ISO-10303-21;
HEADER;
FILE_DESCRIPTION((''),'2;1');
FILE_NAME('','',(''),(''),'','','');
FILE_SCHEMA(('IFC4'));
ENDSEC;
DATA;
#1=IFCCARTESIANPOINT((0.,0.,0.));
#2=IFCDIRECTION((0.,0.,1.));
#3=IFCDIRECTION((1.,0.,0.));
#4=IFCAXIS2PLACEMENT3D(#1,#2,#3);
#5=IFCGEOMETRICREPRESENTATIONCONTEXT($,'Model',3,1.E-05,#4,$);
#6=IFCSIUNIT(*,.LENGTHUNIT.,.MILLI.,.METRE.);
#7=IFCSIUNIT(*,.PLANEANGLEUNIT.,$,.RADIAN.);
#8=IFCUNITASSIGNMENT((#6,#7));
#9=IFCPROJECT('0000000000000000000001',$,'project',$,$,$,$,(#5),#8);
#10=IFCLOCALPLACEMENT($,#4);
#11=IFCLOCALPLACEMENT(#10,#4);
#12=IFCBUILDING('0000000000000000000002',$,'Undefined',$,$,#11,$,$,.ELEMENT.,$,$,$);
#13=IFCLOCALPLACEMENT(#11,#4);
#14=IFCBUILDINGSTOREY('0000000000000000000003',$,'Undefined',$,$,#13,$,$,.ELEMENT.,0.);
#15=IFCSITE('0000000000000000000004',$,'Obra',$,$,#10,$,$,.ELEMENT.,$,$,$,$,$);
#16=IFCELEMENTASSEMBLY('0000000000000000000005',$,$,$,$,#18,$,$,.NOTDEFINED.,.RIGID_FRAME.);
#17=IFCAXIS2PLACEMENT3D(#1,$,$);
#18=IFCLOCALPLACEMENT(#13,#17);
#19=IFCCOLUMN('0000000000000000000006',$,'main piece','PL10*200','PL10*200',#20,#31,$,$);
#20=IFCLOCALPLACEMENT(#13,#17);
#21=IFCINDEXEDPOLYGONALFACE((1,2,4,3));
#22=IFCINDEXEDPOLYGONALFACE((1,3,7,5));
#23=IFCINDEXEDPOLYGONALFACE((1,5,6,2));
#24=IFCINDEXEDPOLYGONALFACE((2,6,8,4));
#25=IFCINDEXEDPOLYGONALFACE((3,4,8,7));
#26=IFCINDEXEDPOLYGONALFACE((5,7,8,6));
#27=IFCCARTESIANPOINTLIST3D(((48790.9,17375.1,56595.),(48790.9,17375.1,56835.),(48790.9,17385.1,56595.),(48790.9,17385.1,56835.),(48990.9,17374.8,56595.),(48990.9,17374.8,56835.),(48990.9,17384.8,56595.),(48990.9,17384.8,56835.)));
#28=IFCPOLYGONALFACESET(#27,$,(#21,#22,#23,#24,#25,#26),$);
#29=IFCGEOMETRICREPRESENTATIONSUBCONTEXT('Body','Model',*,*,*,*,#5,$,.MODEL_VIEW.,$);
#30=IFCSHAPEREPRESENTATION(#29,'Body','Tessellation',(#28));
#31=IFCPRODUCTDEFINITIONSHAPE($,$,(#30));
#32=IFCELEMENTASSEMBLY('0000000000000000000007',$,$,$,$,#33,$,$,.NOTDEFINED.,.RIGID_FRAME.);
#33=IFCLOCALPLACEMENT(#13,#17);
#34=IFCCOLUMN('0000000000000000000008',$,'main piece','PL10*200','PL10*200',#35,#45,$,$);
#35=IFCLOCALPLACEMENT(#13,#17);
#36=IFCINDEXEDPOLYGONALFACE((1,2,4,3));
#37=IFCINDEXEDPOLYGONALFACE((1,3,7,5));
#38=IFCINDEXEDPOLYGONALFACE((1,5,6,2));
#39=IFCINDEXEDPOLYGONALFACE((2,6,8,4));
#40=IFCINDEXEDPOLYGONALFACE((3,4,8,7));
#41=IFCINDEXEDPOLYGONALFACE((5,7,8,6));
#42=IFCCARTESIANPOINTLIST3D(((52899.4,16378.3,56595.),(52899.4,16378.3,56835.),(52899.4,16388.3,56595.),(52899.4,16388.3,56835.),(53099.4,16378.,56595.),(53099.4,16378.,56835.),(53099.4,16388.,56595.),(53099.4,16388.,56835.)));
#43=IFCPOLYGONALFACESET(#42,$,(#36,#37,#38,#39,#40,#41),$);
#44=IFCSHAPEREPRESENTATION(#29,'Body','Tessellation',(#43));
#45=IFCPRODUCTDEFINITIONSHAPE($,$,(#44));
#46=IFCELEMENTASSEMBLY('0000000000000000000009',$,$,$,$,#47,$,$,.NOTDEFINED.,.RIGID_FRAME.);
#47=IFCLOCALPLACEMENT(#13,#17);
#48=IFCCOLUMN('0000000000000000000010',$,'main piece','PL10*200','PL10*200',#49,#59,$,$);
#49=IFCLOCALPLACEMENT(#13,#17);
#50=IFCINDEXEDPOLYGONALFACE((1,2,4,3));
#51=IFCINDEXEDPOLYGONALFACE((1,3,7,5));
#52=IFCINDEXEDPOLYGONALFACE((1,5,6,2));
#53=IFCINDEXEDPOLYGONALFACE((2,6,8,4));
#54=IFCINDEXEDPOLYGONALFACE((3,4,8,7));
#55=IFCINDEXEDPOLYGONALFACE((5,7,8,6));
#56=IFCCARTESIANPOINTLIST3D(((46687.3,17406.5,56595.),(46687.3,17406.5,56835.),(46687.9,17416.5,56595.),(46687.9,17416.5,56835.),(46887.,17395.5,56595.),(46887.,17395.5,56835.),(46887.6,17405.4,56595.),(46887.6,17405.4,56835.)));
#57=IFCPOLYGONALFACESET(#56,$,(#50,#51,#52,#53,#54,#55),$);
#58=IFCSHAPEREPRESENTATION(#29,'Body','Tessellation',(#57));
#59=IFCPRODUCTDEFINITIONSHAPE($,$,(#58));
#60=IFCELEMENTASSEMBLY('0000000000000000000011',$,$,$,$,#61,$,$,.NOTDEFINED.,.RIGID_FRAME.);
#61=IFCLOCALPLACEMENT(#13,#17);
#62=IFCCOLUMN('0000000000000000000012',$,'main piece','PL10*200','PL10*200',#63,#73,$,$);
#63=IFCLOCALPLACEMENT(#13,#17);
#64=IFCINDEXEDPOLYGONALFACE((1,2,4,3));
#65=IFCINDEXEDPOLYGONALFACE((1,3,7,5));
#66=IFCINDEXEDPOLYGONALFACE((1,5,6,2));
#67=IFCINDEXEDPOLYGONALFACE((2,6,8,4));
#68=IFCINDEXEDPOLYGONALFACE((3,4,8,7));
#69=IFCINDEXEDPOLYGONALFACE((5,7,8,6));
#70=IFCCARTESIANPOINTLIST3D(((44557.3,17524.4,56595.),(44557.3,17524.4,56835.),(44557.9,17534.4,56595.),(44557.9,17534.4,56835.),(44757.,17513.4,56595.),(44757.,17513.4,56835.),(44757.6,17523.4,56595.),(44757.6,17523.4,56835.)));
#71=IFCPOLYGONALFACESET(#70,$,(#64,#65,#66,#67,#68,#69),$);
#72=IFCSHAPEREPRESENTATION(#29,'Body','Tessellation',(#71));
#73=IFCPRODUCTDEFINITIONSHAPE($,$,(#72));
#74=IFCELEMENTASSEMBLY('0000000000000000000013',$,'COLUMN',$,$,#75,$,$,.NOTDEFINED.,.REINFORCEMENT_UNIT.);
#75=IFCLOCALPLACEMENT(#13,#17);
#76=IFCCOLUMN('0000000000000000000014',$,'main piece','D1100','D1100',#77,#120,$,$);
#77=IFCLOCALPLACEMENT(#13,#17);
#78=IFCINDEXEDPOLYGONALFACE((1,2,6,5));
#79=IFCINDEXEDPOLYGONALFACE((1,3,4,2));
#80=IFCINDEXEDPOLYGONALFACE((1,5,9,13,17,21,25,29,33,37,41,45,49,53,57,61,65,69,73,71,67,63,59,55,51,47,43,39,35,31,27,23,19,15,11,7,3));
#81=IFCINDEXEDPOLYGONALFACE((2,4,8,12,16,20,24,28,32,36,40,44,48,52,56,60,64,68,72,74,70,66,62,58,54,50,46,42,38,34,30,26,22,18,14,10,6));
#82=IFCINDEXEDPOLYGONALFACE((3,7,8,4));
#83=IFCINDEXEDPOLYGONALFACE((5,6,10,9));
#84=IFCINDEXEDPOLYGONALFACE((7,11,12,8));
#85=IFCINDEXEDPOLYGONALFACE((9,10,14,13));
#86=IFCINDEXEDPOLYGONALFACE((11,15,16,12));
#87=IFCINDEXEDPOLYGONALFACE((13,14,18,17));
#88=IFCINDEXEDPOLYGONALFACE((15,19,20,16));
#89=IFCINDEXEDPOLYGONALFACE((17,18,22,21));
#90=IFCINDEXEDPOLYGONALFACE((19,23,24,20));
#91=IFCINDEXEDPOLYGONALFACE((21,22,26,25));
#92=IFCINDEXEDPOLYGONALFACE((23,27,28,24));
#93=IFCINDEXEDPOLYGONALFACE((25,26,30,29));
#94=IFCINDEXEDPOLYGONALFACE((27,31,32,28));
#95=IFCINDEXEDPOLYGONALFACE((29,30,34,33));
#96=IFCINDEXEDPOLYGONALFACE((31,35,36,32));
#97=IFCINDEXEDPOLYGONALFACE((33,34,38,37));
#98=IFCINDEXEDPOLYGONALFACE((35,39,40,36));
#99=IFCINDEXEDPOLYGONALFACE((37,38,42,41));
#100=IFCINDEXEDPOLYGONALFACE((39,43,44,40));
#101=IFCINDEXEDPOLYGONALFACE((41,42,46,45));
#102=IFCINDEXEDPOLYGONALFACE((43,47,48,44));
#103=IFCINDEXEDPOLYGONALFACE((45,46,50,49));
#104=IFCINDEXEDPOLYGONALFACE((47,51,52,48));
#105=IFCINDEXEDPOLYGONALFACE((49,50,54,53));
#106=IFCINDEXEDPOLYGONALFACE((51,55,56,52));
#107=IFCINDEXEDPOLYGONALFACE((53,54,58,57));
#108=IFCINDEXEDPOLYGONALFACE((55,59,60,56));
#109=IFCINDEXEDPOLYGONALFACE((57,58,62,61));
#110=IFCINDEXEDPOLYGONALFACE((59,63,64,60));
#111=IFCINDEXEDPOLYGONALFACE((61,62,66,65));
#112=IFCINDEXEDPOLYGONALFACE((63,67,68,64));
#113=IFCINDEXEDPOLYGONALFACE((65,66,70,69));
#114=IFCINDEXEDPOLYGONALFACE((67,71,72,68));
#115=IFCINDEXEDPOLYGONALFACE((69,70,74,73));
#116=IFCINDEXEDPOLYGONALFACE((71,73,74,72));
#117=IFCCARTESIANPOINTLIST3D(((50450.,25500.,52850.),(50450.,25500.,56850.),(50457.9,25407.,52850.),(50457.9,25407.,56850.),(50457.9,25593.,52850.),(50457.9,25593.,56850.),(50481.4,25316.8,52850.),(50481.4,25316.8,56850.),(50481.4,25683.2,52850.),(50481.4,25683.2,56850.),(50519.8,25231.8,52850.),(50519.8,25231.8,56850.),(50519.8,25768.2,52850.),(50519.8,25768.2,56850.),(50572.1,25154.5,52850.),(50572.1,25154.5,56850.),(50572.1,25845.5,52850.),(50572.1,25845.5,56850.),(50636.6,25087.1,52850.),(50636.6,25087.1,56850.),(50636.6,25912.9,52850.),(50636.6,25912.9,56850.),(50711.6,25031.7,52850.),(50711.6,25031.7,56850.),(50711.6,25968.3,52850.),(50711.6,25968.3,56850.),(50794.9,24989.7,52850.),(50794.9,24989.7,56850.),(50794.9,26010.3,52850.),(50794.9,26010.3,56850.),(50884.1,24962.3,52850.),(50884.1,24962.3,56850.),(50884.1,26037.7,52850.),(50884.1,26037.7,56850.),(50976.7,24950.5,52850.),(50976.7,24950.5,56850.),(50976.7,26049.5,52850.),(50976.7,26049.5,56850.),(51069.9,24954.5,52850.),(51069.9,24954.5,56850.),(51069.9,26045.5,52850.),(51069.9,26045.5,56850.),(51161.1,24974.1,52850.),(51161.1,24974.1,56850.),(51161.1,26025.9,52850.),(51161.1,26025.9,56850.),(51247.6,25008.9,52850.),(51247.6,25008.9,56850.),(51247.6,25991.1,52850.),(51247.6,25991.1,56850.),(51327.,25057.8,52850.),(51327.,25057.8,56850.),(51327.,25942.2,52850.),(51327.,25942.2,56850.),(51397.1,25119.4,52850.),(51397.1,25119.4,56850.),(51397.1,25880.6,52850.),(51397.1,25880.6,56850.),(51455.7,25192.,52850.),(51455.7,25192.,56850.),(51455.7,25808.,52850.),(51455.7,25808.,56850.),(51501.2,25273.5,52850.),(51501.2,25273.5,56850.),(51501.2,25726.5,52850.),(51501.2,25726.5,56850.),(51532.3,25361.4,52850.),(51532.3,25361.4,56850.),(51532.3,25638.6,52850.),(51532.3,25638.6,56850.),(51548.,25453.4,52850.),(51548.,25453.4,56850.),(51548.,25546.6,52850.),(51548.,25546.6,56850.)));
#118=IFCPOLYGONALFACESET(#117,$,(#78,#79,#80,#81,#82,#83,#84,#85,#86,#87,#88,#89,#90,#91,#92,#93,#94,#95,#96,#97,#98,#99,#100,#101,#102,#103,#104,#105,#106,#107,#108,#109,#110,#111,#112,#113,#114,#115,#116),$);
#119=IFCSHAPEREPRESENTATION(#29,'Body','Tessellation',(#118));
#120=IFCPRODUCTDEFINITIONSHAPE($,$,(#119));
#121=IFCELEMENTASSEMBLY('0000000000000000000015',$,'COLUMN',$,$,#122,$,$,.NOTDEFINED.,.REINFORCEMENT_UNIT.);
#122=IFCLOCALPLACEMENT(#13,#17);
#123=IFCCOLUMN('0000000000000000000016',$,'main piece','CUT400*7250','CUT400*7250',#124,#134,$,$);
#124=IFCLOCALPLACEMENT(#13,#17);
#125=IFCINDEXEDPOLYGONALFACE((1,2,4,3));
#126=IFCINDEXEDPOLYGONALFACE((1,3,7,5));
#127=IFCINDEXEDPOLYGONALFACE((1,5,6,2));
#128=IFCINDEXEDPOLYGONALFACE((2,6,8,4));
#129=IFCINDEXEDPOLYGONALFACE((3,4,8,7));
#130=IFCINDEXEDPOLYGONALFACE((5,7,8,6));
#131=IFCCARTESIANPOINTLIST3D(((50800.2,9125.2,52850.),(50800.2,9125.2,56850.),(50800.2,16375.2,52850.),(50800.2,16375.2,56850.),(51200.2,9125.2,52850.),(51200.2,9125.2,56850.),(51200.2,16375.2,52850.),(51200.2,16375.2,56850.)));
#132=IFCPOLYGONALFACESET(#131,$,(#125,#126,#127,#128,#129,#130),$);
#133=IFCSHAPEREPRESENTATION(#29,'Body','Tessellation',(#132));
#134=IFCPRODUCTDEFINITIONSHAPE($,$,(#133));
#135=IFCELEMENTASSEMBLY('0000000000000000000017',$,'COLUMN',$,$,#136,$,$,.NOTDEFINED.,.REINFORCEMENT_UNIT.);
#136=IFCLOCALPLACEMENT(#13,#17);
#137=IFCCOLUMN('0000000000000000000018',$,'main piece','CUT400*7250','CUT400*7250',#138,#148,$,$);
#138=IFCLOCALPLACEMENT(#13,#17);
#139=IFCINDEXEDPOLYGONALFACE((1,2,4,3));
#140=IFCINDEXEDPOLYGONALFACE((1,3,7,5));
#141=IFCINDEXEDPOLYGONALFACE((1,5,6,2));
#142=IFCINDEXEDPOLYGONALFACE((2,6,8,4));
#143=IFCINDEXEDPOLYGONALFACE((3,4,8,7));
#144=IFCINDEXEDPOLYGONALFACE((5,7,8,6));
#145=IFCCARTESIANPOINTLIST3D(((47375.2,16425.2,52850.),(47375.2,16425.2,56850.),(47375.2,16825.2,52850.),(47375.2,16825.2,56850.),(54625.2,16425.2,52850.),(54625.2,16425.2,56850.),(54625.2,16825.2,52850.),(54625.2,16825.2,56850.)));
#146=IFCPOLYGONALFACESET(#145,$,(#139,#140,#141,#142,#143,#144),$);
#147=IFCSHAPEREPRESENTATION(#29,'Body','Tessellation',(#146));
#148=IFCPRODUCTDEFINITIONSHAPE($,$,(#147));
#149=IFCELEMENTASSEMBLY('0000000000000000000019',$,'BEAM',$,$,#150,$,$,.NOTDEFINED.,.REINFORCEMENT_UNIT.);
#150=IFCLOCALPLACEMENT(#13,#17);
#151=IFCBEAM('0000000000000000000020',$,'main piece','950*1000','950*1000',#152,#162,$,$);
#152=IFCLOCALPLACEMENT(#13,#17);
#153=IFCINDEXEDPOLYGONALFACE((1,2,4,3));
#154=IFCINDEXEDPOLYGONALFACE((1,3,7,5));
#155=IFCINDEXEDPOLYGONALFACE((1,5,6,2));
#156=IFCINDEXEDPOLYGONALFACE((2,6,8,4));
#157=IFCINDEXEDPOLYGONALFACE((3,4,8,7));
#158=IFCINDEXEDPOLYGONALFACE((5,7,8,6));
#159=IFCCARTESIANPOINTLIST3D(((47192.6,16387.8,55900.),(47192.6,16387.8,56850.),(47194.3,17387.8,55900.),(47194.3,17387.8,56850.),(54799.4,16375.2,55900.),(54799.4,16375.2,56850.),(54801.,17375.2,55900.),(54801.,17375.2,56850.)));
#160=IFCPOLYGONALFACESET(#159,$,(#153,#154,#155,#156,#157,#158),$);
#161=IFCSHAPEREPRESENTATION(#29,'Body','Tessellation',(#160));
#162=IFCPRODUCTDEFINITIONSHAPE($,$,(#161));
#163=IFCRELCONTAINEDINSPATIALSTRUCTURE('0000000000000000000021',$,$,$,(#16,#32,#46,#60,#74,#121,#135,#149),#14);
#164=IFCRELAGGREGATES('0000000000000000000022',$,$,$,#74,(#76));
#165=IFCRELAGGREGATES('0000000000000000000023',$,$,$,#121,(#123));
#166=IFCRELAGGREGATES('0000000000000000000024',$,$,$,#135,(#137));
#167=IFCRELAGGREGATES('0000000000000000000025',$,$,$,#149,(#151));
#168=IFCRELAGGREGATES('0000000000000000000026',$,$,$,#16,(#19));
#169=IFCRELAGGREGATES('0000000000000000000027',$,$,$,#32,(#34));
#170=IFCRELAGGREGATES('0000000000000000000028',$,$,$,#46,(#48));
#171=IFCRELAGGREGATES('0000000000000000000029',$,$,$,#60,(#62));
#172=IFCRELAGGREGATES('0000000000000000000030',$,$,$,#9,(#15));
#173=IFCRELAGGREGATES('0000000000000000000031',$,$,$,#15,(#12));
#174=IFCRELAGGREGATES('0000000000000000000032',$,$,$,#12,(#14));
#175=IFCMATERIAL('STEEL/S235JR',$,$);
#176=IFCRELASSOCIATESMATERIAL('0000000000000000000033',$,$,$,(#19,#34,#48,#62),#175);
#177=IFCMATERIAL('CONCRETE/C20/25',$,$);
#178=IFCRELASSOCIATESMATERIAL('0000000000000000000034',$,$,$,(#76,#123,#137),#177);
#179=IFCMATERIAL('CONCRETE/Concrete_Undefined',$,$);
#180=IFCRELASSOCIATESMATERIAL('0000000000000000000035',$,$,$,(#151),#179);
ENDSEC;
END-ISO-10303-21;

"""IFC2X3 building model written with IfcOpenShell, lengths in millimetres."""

from ifc_helpers import new_model, si_unit, frame, origin_with_axes, origin_2d_with_axis, place, context, subcontext, project, spatial, rectangle, circle, extrude, material, element, aggregate, save


model = new_model("IFC2X3")

# Units and contexts
model_context = context("Model", 3, precision=1e-05, world=origin_with_axes())
body_context = subcontext(model_context, "Body", "Model", "MODEL_VIEW")
ifc_project = project(units=[si_unit("LENGTHUNIT", "METRE", prefix="MILLI"), si_unit("PLANEANGLEUNIT", "RADIAN")], contexts=[model_context])

# Site, building, storey
site_placement = place(None, origin_with_axes())
site = spatial("IfcSite", under=ifc_project, at=site_placement, Name="Obra", CompositionType="ELEMENT")
building_placement = place(site_placement, origin_with_axes())
building = spatial("IfcBuilding", under=site, at=building_placement, Name="Undefined", CompositionType="ELEMENT")
storey_placement = place(building_placement, origin_with_axes())
storey = spatial("IfcBuildingStorey", under=building, at=storey_placement, Name="Undefined", CompositionType="ELEMENT", Elevation=0.0)

# Element assemblies, columns
assembly_1_placement = place(storey_placement, origin_with_axes())
assembly_1 = element("IfcElementAssembly", 1, at=assembly_1_placement, inside=storey, AssemblyPlace="NOTDEFINED", PredefinedType="RIGID_FRAME")
ifc_material_1 = material(Name="STEEL/S235JR")
column_1_placement = place(assembly_1_placement, frame((48890.9, 17380.0, 56595.0), z_axis=(0.0, 0.0, 1.0), x_axis=(0.999999, -0.001649, 0.0)))
column_1 = element("IfcColumn", 2, at=column_1_placement, material=ifc_material_1, Name="main piece", Description="PL10*200", ObjectType="PL10*200", context=body_context, shape_type="SweptSolid", body=[
    extrude(rectangle(XDim=10.0, YDim=200.0, at=origin_2d_with_axis()), frame((0.0, 0.0, 240.0), z_axis=(0.0, 0.0, -1.0), x_axis=(0.0, 1.0, 0.0)), (0.0, 0.0, 1.0), 240.0),
])
assembly_2_placement = place(storey_placement, origin_with_axes())
assembly_2 = element("IfcElementAssembly", 3, at=assembly_2_placement, inside=storey, AssemblyPlace="NOTDEFINED", PredefinedType="RIGID_FRAME")
column_2_placement = place(assembly_2_placement, frame((52999.4, 16383.2, 56595.0), z_axis=(0.0, 0.0, 1.0), x_axis=(-0.999999, 0.001649, 0.0)))
column_2 = element("IfcColumn", 4, at=column_2_placement, material=ifc_material_1, Name="main piece", Description="PL10*200", ObjectType="PL10*200", context=body_context, shape_type="SweptSolid", body=[
    extrude(rectangle(XDim=10.0, YDim=200.0, at=origin_2d_with_axis()), frame((0.0, 0.0, 240.0), z_axis=(0.0, 0.0, -1.0), x_axis=(0.0, 1.0, 0.0)), (0.0, 0.0, 1.0), 240.0),
])
assembly_3_placement = place(storey_placement, origin_with_axes())
assembly_3 = element("IfcElementAssembly", 5, at=assembly_3_placement, inside=storey, AssemblyPlace="NOTDEFINED", PredefinedType="RIGID_FRAME")
column_3_placement = place(assembly_3_placement, frame((46787.4, 17406.0, 56595.0), z_axis=(0.0, 0.0, 1.0), x_axis=(0.998472, -0.055268, 0.0)))
column_3 = element("IfcColumn", 6, at=column_3_placement, material=ifc_material_1, Name="main piece", Description="PL10*200", ObjectType="PL10*200", context=body_context, shape_type="SweptSolid", body=[
    extrude(rectangle(XDim=10.0, YDim=200.0, at=origin_2d_with_axis()), frame((0.0, 0.0, 240.0), z_axis=(0.0, 0.0, -1.0), x_axis=(0.0, 1.0, 0.0)), (0.0, 0.0, 1.0), 240.0),
])
assembly_4_placement = place(storey_placement, origin_with_axes())
assembly_4 = element("IfcElementAssembly", 7, at=assembly_4_placement, inside=storey, AssemblyPlace="NOTDEFINED", PredefinedType="RIGID_FRAME")
column_4_placement = place(assembly_4_placement, frame((44657.4, 17523.9, 56595.0), z_axis=(0.0, 0.0, 1.0), x_axis=(0.998472, -0.055268, 0.0)))
column_4 = element("IfcColumn", 8, at=column_4_placement, material=ifc_material_1, Name="main piece", Description="PL10*200", ObjectType="PL10*200", context=body_context, shape_type="SweptSolid", body=[
    extrude(rectangle(XDim=10.0, YDim=200.0, at=origin_2d_with_axis()), frame((0.0, 0.0, 240.0), z_axis=(0.0, 0.0, -1.0), x_axis=(0.0, 1.0, 0.0)), (0.0, 0.0, 1.0), 240.0),
])
assembly_5_placement = place(storey_placement, origin_with_axes())
assembly_5 = element("IfcElementAssembly", 9, at=assembly_5_placement, inside=storey, Name="COLUMN", AssemblyPlace="NOTDEFINED", PredefinedType="REINFORCEMENT_UNIT")
ifc_material_2 = material(Name="CONCRETE/C20/25")
column_5_placement = place(assembly_5_placement, frame((51000.0, 25500.0, 52850.0), z_axis=(0.0, 0.0, 1.0), x_axis=(0.0, 1.0, 0.0)))
column_5 = element("IfcColumn", 10, at=column_5_placement, material=ifc_material_2, Name="main piece", Description="D1100", ObjectType="D1100", context=body_context, shape_type="SweptSolid", body=[
    extrude(circle(Radius=550.0, at=origin_2d_with_axis()), frame((0.0, 0.0, 4000.0), z_axis=(0.0, 0.0, -1.0), x_axis=(0.0, 1.0, 0.0)), (0.0, 0.0, 1.0), 4000.0),
])
aggregate(assembly_5, [column_5])
assembly_6_placement = place(storey_placement, origin_with_axes())
assembly_6 = element("IfcElementAssembly", 11, at=assembly_6_placement, inside=storey, Name="COLUMN", AssemblyPlace="NOTDEFINED", PredefinedType="REINFORCEMENT_UNIT")
column_6_placement = place(assembly_6_placement, frame((51000.2, 12750.2, 52850.0), z_axis=(0.0, 0.0, 1.0), x_axis=(0.0, -1.0, 0.0)))
column_6 = element("IfcColumn", 12, at=column_6_placement, material=ifc_material_2, Name="main piece", Description="CUT400*7250", ObjectType="CUT400*7250", context=body_context, shape_type="SweptSolid", body=[
    extrude(rectangle(XDim=400.0, YDim=7250.0, at=origin_2d_with_axis()), frame((0.0, 0.0, 4000.0), z_axis=(0.0, 0.0, -1.0), x_axis=(0.0, 1.0, 0.0)), (0.0, 0.0, 1.0), 4000.0),
])
aggregate(assembly_6, [column_6])
assembly_7_placement = place(storey_placement, origin_with_axes())
assembly_7 = element("IfcElementAssembly", 13, at=assembly_7_placement, inside=storey, Name="COLUMN", AssemblyPlace="NOTDEFINED", PredefinedType="REINFORCEMENT_UNIT")
column_7_placement = place(assembly_7_placement, frame((51000.2, 16625.2, 52850.0), z_axis=(0.0, 0.0, 1.0), x_axis=(-1.0, 0.0, 0.0)))
column_7 = element("IfcColumn", 14, at=column_7_placement, material=ifc_material_2, Name="main piece", Description="CUT400*7250", ObjectType="CUT400*7250", context=body_context, shape_type="SweptSolid", body=[
    extrude(rectangle(XDim=400.0, YDim=7250.0, at=origin_2d_with_axis()), frame((0.0, 0.0, 4000.0), z_axis=(0.0, 0.0, -1.0), x_axis=(0.0, 1.0, 0.0)), (0.0, 0.0, 1.0), 4000.0),
])
aggregate(assembly_7, [column_7])

# Element assembly, beam
assembly_8_placement = place(storey_placement, origin_with_axes())
assembly_8 = element("IfcElementAssembly", 15, at=assembly_8_placement, inside=storey, Name="BEAM", AssemblyPlace="NOTDEFINED", PredefinedType="REINFORCEMENT_UNIT")
ifc_material_3 = material(Name="CONCRETE/Concrete_Undefined")
beam_1_placement = place(assembly_8_placement, frame((47193.5, 16887.8, 56375.0), z_axis=(0.0, 0.0, 1.0), x_axis=(0.999999, -0.001649, 0.0)))
beam_1 = element("IfcBeam", 16, at=beam_1_placement, material=ifc_material_3, Name="main piece", Description="950*1000", ObjectType="950*1000", context=body_context, shape_type="SweptSolid", body=[
    extrude(rectangle(XDim=1000.0, YDim=950.0, at=origin_2d_with_axis()), frame((7606.8, 0.0, 0.0), z_axis=(-1.0, 0.0, 0.0), x_axis=(0.0, -1.0, 0.0)), (0.0, 0.0, 1.0), 7606.8),
])
aggregate(assembly_8, [beam_1])

aggregate(assembly_1, [column_1])
aggregate(assembly_2, [column_2])
aggregate(assembly_3, [column_3])
aggregate(assembly_4, [column_4])

save(model, "model.ifc")
